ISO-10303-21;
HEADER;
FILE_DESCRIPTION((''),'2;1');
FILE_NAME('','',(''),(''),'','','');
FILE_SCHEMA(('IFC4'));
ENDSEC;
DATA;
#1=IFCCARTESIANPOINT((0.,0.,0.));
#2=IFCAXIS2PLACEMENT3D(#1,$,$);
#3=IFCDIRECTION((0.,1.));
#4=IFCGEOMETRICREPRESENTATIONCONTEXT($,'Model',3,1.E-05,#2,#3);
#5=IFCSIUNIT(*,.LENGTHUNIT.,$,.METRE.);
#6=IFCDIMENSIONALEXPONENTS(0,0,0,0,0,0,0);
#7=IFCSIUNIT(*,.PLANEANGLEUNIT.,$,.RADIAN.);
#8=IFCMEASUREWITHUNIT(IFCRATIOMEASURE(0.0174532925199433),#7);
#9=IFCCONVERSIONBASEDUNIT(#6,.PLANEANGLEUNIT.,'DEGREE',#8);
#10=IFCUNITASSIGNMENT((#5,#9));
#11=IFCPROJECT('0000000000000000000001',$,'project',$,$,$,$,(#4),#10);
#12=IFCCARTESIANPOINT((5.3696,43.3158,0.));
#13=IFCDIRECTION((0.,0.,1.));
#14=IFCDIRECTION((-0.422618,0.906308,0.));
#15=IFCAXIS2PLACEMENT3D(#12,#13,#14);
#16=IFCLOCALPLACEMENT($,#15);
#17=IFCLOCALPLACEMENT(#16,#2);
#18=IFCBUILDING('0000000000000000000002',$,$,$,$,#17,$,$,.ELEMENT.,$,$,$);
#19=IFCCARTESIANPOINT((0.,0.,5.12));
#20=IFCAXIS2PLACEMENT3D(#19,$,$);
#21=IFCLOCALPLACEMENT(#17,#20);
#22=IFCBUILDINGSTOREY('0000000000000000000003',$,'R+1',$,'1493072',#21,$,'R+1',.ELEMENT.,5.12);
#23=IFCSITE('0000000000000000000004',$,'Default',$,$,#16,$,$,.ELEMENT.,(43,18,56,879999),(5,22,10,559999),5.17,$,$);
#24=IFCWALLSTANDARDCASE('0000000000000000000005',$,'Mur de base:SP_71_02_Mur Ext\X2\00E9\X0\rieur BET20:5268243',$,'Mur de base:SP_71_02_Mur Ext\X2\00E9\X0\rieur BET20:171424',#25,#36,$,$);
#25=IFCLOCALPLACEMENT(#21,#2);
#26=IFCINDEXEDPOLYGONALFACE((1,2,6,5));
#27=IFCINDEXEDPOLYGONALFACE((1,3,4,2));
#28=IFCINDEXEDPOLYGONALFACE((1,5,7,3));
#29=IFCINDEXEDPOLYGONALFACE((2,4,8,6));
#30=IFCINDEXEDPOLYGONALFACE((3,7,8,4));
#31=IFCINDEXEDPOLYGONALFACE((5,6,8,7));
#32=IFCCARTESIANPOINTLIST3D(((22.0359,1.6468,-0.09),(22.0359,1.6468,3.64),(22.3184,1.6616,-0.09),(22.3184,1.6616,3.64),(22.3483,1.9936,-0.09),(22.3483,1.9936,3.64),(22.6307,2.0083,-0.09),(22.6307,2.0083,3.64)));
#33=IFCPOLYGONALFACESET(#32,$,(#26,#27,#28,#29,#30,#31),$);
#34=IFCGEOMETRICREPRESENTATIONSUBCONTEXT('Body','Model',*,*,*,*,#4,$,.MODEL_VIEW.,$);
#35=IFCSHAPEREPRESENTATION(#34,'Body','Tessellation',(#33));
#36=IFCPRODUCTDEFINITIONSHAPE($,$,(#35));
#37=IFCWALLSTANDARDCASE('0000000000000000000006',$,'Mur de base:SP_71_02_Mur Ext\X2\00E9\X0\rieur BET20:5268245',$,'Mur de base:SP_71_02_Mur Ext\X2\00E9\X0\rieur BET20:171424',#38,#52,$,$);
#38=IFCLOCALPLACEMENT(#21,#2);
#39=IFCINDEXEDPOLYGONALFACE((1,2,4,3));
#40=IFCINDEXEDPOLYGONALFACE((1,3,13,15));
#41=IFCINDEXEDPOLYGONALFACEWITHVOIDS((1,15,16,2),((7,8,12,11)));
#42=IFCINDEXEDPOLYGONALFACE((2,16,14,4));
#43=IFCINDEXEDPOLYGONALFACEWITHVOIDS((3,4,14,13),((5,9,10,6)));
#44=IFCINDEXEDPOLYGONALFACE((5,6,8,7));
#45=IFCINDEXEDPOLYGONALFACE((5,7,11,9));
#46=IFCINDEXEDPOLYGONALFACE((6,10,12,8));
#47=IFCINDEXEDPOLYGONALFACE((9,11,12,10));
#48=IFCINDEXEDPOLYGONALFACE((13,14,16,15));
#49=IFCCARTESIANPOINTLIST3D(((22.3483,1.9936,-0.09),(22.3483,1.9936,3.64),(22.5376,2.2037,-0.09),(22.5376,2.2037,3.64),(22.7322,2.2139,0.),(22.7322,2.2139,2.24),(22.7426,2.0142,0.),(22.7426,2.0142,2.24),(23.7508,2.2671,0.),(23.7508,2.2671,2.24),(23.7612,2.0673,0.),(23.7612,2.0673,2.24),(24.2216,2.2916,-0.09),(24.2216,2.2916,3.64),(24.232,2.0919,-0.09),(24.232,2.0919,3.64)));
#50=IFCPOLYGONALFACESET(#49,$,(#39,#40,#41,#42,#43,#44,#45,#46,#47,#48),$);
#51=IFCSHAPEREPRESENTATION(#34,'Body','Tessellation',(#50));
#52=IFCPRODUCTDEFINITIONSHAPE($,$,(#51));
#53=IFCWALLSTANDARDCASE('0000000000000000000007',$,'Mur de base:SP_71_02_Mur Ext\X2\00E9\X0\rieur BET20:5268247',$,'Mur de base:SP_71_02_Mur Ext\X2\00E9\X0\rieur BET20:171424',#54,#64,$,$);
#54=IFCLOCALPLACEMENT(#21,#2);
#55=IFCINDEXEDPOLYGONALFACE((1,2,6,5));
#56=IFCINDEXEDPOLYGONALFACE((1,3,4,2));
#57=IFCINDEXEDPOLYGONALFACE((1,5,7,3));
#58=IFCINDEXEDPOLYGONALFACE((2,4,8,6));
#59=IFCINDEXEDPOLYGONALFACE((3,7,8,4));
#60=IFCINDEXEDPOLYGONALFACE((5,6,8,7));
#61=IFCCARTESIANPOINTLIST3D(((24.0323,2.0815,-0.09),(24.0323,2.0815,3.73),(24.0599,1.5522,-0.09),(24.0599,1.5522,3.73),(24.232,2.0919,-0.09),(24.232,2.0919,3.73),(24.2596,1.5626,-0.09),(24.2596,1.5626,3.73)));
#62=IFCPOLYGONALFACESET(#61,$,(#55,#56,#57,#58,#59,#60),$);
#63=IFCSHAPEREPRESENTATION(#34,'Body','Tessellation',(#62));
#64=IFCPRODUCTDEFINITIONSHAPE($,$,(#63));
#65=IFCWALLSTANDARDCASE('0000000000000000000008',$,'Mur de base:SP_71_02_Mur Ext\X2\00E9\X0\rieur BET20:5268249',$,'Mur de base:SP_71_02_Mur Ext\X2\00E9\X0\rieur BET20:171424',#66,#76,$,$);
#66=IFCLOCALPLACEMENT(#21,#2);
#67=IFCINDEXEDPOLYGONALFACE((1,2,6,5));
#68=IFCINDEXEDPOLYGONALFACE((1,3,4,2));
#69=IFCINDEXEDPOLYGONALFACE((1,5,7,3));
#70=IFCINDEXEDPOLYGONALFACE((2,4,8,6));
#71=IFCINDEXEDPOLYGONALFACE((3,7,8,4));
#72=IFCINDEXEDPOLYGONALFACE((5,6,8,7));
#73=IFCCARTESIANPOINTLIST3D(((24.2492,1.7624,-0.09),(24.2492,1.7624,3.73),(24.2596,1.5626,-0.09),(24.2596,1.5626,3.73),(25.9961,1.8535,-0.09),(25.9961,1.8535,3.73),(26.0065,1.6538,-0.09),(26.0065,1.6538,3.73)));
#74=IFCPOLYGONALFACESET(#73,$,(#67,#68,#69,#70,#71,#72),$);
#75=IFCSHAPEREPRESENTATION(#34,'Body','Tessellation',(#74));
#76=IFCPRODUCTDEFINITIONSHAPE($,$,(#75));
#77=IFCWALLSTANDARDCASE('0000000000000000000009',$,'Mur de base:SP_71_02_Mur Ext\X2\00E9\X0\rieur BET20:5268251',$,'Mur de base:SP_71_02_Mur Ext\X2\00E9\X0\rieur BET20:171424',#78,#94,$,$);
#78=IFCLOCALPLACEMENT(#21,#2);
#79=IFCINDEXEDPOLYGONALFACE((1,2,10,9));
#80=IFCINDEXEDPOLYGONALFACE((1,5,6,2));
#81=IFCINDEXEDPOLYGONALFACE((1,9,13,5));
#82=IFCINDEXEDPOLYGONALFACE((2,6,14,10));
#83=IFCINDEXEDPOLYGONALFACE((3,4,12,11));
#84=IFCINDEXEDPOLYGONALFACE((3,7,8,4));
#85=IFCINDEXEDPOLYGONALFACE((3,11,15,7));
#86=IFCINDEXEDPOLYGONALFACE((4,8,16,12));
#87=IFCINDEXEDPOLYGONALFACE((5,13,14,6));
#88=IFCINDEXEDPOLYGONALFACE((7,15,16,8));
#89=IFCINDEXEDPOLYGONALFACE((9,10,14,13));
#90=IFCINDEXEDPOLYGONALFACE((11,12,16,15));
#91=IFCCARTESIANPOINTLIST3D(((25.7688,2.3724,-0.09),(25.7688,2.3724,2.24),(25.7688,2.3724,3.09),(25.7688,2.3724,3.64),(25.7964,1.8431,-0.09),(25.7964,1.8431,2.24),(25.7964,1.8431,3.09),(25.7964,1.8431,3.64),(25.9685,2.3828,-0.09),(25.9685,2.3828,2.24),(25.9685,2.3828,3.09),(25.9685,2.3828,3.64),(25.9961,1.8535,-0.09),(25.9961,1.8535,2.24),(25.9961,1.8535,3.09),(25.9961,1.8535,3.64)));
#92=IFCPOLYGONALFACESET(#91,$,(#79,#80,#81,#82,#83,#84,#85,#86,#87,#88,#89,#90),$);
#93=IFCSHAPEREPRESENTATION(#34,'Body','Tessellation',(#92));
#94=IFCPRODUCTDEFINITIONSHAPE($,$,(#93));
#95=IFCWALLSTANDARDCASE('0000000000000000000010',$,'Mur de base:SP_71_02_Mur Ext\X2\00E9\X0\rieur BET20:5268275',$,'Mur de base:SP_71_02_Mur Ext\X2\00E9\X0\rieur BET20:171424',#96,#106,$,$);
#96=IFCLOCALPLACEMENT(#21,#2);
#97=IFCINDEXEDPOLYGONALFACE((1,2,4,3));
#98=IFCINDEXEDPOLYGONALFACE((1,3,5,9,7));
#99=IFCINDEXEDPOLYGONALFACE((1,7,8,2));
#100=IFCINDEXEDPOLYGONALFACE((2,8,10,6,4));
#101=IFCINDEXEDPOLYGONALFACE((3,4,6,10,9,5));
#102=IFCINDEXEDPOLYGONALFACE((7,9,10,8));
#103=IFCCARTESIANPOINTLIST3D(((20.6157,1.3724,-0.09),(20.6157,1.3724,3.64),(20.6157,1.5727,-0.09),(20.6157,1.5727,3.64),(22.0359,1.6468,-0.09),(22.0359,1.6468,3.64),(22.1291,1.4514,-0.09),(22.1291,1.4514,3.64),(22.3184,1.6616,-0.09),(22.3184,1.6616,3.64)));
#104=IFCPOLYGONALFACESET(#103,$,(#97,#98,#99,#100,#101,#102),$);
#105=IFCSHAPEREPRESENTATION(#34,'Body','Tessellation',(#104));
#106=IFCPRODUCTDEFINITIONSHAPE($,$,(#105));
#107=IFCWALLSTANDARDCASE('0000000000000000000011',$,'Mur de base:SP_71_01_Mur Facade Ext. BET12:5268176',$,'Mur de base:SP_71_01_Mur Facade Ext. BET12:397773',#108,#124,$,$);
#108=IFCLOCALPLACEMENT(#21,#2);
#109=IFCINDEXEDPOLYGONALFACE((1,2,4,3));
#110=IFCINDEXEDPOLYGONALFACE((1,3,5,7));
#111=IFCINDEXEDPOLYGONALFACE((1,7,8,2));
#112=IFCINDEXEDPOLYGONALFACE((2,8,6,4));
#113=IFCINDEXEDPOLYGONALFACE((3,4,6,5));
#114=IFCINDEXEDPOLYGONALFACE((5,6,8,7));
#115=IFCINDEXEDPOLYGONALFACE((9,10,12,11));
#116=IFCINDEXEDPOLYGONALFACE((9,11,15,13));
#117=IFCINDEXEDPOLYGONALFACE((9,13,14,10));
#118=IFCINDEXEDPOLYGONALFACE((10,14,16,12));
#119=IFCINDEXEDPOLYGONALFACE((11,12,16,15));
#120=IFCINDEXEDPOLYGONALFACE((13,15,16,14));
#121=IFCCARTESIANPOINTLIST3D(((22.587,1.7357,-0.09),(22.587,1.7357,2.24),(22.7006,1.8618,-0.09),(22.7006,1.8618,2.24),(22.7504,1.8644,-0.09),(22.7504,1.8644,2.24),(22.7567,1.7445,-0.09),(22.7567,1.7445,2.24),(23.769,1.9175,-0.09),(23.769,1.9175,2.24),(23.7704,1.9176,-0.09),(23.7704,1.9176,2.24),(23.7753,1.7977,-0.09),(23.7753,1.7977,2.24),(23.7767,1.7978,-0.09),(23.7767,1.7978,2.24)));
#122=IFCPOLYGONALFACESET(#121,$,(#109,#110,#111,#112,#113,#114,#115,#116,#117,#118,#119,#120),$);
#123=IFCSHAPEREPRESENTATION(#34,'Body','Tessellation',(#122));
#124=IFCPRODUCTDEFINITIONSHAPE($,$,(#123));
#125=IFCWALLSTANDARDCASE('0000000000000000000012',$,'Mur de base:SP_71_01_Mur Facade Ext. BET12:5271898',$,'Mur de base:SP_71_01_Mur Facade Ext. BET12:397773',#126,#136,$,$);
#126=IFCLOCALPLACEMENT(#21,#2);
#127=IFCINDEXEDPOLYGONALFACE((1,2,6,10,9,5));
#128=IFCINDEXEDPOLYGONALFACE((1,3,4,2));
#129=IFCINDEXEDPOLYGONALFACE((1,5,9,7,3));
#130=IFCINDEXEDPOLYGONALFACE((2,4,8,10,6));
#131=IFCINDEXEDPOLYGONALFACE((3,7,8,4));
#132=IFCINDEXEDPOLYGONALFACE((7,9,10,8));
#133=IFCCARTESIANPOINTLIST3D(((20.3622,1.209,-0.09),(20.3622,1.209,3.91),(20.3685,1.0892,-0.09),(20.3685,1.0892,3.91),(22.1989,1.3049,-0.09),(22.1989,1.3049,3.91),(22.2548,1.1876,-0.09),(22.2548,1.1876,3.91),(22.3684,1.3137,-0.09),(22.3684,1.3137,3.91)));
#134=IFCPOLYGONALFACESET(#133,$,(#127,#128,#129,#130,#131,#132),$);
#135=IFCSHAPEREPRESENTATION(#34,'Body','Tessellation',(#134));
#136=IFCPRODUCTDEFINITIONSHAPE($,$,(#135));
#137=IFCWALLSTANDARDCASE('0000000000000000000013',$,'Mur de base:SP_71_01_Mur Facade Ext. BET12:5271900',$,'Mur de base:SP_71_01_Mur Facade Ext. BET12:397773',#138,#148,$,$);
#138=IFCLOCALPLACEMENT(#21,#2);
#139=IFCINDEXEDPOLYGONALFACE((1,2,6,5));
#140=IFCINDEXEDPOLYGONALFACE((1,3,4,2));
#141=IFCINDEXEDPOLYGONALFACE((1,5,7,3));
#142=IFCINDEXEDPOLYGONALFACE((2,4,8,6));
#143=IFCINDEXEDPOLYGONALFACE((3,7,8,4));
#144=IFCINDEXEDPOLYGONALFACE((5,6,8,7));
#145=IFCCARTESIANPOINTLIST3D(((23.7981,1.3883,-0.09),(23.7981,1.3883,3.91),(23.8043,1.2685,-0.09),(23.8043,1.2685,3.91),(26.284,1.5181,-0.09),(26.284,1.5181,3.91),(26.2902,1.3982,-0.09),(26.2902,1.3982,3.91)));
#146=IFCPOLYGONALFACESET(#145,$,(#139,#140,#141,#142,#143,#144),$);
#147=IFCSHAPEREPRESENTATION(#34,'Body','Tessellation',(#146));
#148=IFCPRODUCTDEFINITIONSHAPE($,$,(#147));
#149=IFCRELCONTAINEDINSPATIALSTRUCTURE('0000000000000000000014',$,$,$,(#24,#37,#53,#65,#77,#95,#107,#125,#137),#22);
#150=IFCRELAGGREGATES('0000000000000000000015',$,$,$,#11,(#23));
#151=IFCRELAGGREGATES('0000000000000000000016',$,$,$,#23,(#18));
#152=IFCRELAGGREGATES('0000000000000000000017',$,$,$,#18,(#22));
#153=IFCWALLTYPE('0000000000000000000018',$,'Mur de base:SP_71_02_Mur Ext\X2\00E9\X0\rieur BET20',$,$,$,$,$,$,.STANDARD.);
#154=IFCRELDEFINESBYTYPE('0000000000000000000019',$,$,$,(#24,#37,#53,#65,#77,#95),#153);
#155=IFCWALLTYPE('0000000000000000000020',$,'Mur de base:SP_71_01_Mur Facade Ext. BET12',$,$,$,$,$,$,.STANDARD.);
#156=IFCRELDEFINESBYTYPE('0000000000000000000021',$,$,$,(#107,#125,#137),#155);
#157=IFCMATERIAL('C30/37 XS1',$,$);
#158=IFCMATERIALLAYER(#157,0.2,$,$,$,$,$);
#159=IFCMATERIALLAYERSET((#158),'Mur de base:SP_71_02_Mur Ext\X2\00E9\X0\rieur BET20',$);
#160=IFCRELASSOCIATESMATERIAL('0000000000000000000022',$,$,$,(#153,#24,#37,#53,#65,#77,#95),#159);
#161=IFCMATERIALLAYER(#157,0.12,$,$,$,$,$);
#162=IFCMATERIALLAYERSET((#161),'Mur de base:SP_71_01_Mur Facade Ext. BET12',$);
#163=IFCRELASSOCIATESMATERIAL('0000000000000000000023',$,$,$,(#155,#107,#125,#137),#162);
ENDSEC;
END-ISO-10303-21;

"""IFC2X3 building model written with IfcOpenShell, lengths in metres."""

from ifc_helpers import new_model, entity, si_unit, converted_unit, direction, frame, frame_2d, origin, origin_2d_with_axis, place, context, subcontext, project, spatial, polyline, rectangle, outline, extrude, clip, bounded_halfspace, material, layer, layer_set, layer_usage, type_object, element, save


model = new_model("IFC2X3")

# Units and contexts
model_context = context("Model", 3, precision=1e-05, world=origin(), true_north=direction((0.0, 1.0)))
body_context = subcontext(model_context, "Body", "Model", "MODEL_VIEW")
ifc_project = project(units=[si_unit("LENGTHUNIT", "METRE"), converted_unit("PLANEANGLEUNIT", "DEGREE", entity("IfcRatioMeasure", 0.0174532925199433), si_unit("PLANEANGLEUNIT", "RADIAN"), dimensions=[0, 0, 0, 0, 0, 0, 0])], contexts=[model_context])

# Site, building, storey
site_placement = place(None, frame((5.3696, 43.3158, 0.0), z_axis=(0.0, 0.0, 1.0), x_axis=(-0.422618, 0.906308, 0.0)))
site = spatial("IfcSite", under=ifc_project, at=site_placement, Name="Default", CompositionType="ELEMENT", RefLatitude=(43, 18, 56, 879999), RefLongitude=(5, 22, 10, 559999), RefElevation=5.17)
building_placement = place(site_placement, origin())
building = spatial("IfcBuilding", under=site, at=building_placement, CompositionType="ELEMENT")
storey_placement = place(building_placement, frame((0.0, 0.0, 5.12)))
storey = spatial("IfcBuildingStorey", under=building, at=storey_placement, Name="R+1", ObjectType="1493072", LongName="R+1", CompositionType="ELEMENT", Elevation=5.12)

# Wall
ifc_material_1 = material(Name="C30/37 XS1")
ifc_layer_1 = layer(ifc_material_1, 0.2)
ifc_layer_set_1 = layer_set([ifc_layer_1], Name="Mur de base:SP_71_02_Mur Extérieur BET20")
ifc_layer_usage_1 = layer_usage(ifc_layer_set_1, "AXIS2", "NEGATIVE", 0.1)
wall_type_1 = type_object("IfcWallType", Name="Mur de base:SP_71_02_Mur Extérieur BET20", PredefinedType="STANDARD", material=ifc_layer_set_1)
wall_1_placement = place(storey_placement, frame((22.1102, 1.5799, -0.09), z_axis=(0.0, 0.0, 1.0), x_axis=(0.669291, 0.743, 0.0)))
element("IfcWallStandardCase", 1, at=wall_1_placement, inside=storey, type_object=wall_type_1, material=ifc_layer_usage_1, Name="Mur de base:SP_71_02_Mur Extérieur BET20:5268243", ObjectType="Mur de base:SP_71_02_Mur Extérieur BET20:171424", context=body_context, shape_type="SweptSolid", body=[
    extrude(outline(polyline([(0.6667, -0.1), (0.4667, 0.1), (0.0, 0.1), (0.2, -0.1), (0.6667, -0.1)])), origin(), (0.0, 0.0, 1.0), 3.73),
])

# Wall, opening
ifc_layer_usage_2 = layer_usage(ifc_layer_set_1, "AXIS2", "NEGATIVE", 0.1)
wall_2_placement = place(storey_placement, frame((22.3431, 2.0935, -0.09), z_axis=(0.0, 0.0, 1.0), x_axis=(0.998641, 0.05212, 0.0)))
wall_2 = element("IfcWallStandardCase", 2, at=wall_2_placement, inside=storey, type_object=wall_type_1, material=ifc_layer_usage_2, Name="Mur de base:SP_71_02_Mur Extérieur BET20:5268245", ObjectType="Mur de base:SP_71_02_Mur Extérieur BET20:171424", context=body_context, shape_type="SweptSolid", body=[
    extrude(outline(polyline([(1.8863, -0.1), (1.8863, 0.1), (0.2, 0.1), (0.0, -0.1), (0.2828, -0.1), (1.6863, -0.1), (1.8863, -0.1)])), origin(), (0.0, 0.0, 1.0), 3.73),
])
opening_1_placement = place(wall_2_placement, origin())
element("IfcOpeningElement", 3, at=opening_1_placement, cuts=wall_2, ObjectType="Opening", context=body_context, shape_type="SweptSolid", body=[
    extrude(rectangle(XDim=2.24, YDim=1.02, at=origin_2d_with_axis()), frame((0.9048, -1.424, 1.21), z_axis=(0.0, 1.0, 0.0), x_axis=(0.0, 0.0, -1.0)), (0.0, 0.0, 1.0), 3.048),
])

# Walls
ifc_layer_usage_3 = layer_usage(ifc_layer_set_1, "AXIS2", "NEGATIVE", 0.1)
wall_3_placement = place(storey_placement, frame((24.1597, 1.5574, -0.09), z_axis=(0.0, 0.0, 1.0), x_axis=(-0.05212, 0.998641, 0.0)))
element("IfcWallStandardCase", 4, at=wall_3_placement, inside=storey, type_object=wall_type_1, material=ifc_layer_usage_3, Name="Mur de base:SP_71_02_Mur Extérieur BET20:5268247", ObjectType="Mur de base:SP_71_02_Mur Extérieur BET20:171424", context=body_context, shape_type="SweptSolid", body=[
    extrude(rectangle(XDim=0.53, YDim=0.2, at=frame_2d((0.265, 0.0), x_axis=(-1.0, 0.0))), origin(), (0.0, 0.0, 1.0), 3.82),
])
ifc_layer_usage_4 = layer_usage(ifc_layer_set_1, "AXIS2", "NEGATIVE", 0.1)
wall_4_placement = place(storey_placement, frame((26.0013, 1.7537, -0.09), z_axis=(0.0, 0.0, 1.0), x_axis=(-0.998641, -0.05212, 0.0)))
element("IfcWallStandardCase", 5, at=wall_4_placement, inside=storey, type_object=wall_type_1, material=ifc_layer_usage_4, Name="Mur de base:SP_71_02_Mur Extérieur BET20:5268249", ObjectType="Mur de base:SP_71_02_Mur Extérieur BET20:171424", context=body_context, shape_type="Clipping", body=[
    clip(extrude(rectangle(XDim=1.7493, YDim=0.2, at=frame_2d((0.8747, 0.0), x_axis=(-1.0, 0.0))), origin(), (0.0, 0.0, 1.0), 3.82), bounded_halfspace(frame((1.122, -0.1, 3.18), z_axis=(0.998641, -0.05212, 0.0), x_axis=(0.0, 0.0, -1.0)), True, frame((1.122, -0.1, 3.18), z_axis=(0.998641, -0.05212, 0.0), x_axis=(0.0, 0.0, -1.0)), polyline([(0.0, 0.0), (0.85, 0.0), (0.85, 0.2003), (0.0, 0.2003), (0.0, 0.0)]))),
])

# Wall, opening
ifc_layer_usage_5 = layer_usage(ifc_layer_set_1, "AXIS2", "NEGATIVE", 0.1)
wall_5_placement = place(storey_placement, frame((25.8686, 2.3776, -0.09), z_axis=(0.0, 0.0, 1.0), x_axis=(0.05212, -0.998641, 0.0)))
wall_5 = element("IfcWallStandardCase", 6, at=wall_5_placement, inside=storey, type_object=wall_type_1, material=ifc_layer_usage_5, Name="Mur de base:SP_71_02_Mur Extérieur BET20:5268251", ObjectType="Mur de base:SP_71_02_Mur Extérieur BET20:171424", context=body_context, shape_type="SweptSolid", body=[
    extrude(rectangle(XDim=0.53, YDim=0.2, at=frame_2d((0.265, 0.0), x_axis=(-1.0, 0.0))), origin(), (0.0, 0.0, 1.0), 3.73),
])
opening_2_placement = place(storey_placement, frame((25.8686, 2.3776, -0.09), z_axis=(0.0, 0.0, 1.0), x_axis=(0.05212, -0.998641, 0.0)))
element("IfcOpeningElement", 7, at=opening_2_placement, cuts=wall_5, ObjectType="Opening", context=body_context, shape_type="SweptSolid", body=[
    extrude(rectangle(XDim=0.53, YDim=0.2, at=frame_2d((0.013, -0.02), x_axis=(1.0, 0.0))), frame((0.252, 0.02, 2.33)), (0.0, 0.0, 1.0), 0.85),
])

# Wall
ifc_layer_usage_6 = layer_usage(ifc_layer_set_1, "AXIS2", "NEGATIVE", 0.1)
wall_6_placement = place(storey_placement, frame((20.6104, 1.4723, -0.09), z_axis=(0.0, 0.0, 1.0), x_axis=(0.998641, 0.05212, 0.0)))
element("IfcWallStandardCase", 8, at=wall_6_placement, inside=storey, type_object=wall_type_1, material=ifc_layer_usage_6, Name="Mur de base:SP_71_02_Mur Extérieur BET20:5268275", ObjectType="Mur de base:SP_71_02_Mur Extérieur BET20:171424", context=body_context, shape_type="SweptSolid", body=[
    extrude(outline(polyline([(1.5155, -0.1), (1.7155, 0.1), (1.4326, 0.1), (0.0104, 0.1), (0.0, -0.1), (1.5155, -0.1)])), origin(), (0.0, 0.0, 1.0), 3.73),
])

# Wall, opening
ifc_layer_2 = layer(ifc_material_1, 0.12)
ifc_layer_set_2 = layer_set([ifc_layer_2], Name="Mur de base:SP_71_01_Mur Facade Ext. BET12")
ifc_layer_usage_7 = layer_usage(ifc_layer_set_2, "AXIS2", "NEGATIVE", 0.06)
wall_type_2 = type_object("IfcWallType", Name="Mur de base:SP_71_01_Mur Facade Ext. BET12", PredefinedType="STANDARD", material=ifc_layer_set_2)
wall_7_placement = place(storey_placement, frame((23.7736, 1.8577, -0.09), z_axis=(0.0, 0.0, 1.0), x_axis=(-0.998641, -0.05212, 0.0)))
wall_7 = element("IfcWallStandardCase", 9, at=wall_7_placement, inside=storey, type_object=wall_type_2, material=ifc_layer_usage_7, Name="Mur de base:SP_71_01_Mur Facade Ext. BET12:5268176", ObjectType="Mur de base:SP_71_01_Mur Facade Ext. BET12:397773", context=body_context, shape_type="SweptSolid", body=[
    extrude(outline(polyline([(0.0, -0.06), (1.0713, -0.06), (1.1913, 0.06), (0.0, 0.06), (0.0, -0.06)])), origin(), (0.0, 0.0, 1.0), 2.33),
])
opening_3_placement = place(wall_7_placement, origin())
element("IfcOpeningElement", 10, at=opening_3_placement, cuts=wall_7, ObjectType="Opening", context=body_context, shape_type="SweptSolid", body=[
    extrude(rectangle(XDim=2.33, YDim=1.02, at=frame_2d((0.0, 0.0), x_axis=(0.0, 1.0))), frame((0.5114, -1.584, 1.165), z_axis=(0.0, 1.0, 0.0), x_axis=(1.0, 0.0, 0.0)), (0.0, 0.0, 1.0), 3.048),
])

# Walls
ifc_layer_usage_8 = layer_usage(ifc_layer_set_2, "AXIS2", "NEGATIVE", 0.06)
wall_8_placement = place(storey_placement, frame((22.3715, 1.2538, -0.09), z_axis=(0.0, 0.0, 1.0), x_axis=(-0.998641, -0.05212, 0.0)))
element("IfcWallStandardCase", 11, at=wall_8_placement, inside=storey, type_object=wall_type_2, material=ifc_layer_usage_8, Name="Mur de base:SP_71_01_Mur Facade Ext. BET12:5271898", ObjectType="Mur de base:SP_71_01_Mur Facade Ext. BET12:397773", context=body_context, shape_type="SweptSolid", body=[
    extrude(outline(polyline([(2.0089, -0.06), (2.0089, 0.06), (0.12, 0.06), (0.0, -0.06), (0.1697, -0.06), (2.0089, -0.06)])), origin(), (0.0, 0.0, 1.0), 4.0),
])
ifc_layer_usage_9 = layer_usage(ifc_layer_set_2, "AXIS2", "NEGATIVE", 0.06)
wall_9_placement = place(storey_placement, frame((26.2871, 1.4581, -0.09), z_axis=(0.0, 0.0, 1.0), x_axis=(-0.998641, -0.05212, 0.0)))
element("IfcWallStandardCase", 12, at=wall_9_placement, inside=storey, type_object=wall_type_2, material=ifc_layer_usage_9, Name="Mur de base:SP_71_01_Mur Facade Ext. BET12:5271900", ObjectType="Mur de base:SP_71_01_Mur Facade Ext. BET12:397773", context=body_context, shape_type="SweptSolid", body=[
    extrude(rectangle(XDim=2.4893, YDim=0.12, at=frame_2d((1.2447, 0.0), x_axis=(-1.0, 0.0))), origin(), (0.0, 0.0, 1.0), 4.0),
])

save(model, "model.ifc")
